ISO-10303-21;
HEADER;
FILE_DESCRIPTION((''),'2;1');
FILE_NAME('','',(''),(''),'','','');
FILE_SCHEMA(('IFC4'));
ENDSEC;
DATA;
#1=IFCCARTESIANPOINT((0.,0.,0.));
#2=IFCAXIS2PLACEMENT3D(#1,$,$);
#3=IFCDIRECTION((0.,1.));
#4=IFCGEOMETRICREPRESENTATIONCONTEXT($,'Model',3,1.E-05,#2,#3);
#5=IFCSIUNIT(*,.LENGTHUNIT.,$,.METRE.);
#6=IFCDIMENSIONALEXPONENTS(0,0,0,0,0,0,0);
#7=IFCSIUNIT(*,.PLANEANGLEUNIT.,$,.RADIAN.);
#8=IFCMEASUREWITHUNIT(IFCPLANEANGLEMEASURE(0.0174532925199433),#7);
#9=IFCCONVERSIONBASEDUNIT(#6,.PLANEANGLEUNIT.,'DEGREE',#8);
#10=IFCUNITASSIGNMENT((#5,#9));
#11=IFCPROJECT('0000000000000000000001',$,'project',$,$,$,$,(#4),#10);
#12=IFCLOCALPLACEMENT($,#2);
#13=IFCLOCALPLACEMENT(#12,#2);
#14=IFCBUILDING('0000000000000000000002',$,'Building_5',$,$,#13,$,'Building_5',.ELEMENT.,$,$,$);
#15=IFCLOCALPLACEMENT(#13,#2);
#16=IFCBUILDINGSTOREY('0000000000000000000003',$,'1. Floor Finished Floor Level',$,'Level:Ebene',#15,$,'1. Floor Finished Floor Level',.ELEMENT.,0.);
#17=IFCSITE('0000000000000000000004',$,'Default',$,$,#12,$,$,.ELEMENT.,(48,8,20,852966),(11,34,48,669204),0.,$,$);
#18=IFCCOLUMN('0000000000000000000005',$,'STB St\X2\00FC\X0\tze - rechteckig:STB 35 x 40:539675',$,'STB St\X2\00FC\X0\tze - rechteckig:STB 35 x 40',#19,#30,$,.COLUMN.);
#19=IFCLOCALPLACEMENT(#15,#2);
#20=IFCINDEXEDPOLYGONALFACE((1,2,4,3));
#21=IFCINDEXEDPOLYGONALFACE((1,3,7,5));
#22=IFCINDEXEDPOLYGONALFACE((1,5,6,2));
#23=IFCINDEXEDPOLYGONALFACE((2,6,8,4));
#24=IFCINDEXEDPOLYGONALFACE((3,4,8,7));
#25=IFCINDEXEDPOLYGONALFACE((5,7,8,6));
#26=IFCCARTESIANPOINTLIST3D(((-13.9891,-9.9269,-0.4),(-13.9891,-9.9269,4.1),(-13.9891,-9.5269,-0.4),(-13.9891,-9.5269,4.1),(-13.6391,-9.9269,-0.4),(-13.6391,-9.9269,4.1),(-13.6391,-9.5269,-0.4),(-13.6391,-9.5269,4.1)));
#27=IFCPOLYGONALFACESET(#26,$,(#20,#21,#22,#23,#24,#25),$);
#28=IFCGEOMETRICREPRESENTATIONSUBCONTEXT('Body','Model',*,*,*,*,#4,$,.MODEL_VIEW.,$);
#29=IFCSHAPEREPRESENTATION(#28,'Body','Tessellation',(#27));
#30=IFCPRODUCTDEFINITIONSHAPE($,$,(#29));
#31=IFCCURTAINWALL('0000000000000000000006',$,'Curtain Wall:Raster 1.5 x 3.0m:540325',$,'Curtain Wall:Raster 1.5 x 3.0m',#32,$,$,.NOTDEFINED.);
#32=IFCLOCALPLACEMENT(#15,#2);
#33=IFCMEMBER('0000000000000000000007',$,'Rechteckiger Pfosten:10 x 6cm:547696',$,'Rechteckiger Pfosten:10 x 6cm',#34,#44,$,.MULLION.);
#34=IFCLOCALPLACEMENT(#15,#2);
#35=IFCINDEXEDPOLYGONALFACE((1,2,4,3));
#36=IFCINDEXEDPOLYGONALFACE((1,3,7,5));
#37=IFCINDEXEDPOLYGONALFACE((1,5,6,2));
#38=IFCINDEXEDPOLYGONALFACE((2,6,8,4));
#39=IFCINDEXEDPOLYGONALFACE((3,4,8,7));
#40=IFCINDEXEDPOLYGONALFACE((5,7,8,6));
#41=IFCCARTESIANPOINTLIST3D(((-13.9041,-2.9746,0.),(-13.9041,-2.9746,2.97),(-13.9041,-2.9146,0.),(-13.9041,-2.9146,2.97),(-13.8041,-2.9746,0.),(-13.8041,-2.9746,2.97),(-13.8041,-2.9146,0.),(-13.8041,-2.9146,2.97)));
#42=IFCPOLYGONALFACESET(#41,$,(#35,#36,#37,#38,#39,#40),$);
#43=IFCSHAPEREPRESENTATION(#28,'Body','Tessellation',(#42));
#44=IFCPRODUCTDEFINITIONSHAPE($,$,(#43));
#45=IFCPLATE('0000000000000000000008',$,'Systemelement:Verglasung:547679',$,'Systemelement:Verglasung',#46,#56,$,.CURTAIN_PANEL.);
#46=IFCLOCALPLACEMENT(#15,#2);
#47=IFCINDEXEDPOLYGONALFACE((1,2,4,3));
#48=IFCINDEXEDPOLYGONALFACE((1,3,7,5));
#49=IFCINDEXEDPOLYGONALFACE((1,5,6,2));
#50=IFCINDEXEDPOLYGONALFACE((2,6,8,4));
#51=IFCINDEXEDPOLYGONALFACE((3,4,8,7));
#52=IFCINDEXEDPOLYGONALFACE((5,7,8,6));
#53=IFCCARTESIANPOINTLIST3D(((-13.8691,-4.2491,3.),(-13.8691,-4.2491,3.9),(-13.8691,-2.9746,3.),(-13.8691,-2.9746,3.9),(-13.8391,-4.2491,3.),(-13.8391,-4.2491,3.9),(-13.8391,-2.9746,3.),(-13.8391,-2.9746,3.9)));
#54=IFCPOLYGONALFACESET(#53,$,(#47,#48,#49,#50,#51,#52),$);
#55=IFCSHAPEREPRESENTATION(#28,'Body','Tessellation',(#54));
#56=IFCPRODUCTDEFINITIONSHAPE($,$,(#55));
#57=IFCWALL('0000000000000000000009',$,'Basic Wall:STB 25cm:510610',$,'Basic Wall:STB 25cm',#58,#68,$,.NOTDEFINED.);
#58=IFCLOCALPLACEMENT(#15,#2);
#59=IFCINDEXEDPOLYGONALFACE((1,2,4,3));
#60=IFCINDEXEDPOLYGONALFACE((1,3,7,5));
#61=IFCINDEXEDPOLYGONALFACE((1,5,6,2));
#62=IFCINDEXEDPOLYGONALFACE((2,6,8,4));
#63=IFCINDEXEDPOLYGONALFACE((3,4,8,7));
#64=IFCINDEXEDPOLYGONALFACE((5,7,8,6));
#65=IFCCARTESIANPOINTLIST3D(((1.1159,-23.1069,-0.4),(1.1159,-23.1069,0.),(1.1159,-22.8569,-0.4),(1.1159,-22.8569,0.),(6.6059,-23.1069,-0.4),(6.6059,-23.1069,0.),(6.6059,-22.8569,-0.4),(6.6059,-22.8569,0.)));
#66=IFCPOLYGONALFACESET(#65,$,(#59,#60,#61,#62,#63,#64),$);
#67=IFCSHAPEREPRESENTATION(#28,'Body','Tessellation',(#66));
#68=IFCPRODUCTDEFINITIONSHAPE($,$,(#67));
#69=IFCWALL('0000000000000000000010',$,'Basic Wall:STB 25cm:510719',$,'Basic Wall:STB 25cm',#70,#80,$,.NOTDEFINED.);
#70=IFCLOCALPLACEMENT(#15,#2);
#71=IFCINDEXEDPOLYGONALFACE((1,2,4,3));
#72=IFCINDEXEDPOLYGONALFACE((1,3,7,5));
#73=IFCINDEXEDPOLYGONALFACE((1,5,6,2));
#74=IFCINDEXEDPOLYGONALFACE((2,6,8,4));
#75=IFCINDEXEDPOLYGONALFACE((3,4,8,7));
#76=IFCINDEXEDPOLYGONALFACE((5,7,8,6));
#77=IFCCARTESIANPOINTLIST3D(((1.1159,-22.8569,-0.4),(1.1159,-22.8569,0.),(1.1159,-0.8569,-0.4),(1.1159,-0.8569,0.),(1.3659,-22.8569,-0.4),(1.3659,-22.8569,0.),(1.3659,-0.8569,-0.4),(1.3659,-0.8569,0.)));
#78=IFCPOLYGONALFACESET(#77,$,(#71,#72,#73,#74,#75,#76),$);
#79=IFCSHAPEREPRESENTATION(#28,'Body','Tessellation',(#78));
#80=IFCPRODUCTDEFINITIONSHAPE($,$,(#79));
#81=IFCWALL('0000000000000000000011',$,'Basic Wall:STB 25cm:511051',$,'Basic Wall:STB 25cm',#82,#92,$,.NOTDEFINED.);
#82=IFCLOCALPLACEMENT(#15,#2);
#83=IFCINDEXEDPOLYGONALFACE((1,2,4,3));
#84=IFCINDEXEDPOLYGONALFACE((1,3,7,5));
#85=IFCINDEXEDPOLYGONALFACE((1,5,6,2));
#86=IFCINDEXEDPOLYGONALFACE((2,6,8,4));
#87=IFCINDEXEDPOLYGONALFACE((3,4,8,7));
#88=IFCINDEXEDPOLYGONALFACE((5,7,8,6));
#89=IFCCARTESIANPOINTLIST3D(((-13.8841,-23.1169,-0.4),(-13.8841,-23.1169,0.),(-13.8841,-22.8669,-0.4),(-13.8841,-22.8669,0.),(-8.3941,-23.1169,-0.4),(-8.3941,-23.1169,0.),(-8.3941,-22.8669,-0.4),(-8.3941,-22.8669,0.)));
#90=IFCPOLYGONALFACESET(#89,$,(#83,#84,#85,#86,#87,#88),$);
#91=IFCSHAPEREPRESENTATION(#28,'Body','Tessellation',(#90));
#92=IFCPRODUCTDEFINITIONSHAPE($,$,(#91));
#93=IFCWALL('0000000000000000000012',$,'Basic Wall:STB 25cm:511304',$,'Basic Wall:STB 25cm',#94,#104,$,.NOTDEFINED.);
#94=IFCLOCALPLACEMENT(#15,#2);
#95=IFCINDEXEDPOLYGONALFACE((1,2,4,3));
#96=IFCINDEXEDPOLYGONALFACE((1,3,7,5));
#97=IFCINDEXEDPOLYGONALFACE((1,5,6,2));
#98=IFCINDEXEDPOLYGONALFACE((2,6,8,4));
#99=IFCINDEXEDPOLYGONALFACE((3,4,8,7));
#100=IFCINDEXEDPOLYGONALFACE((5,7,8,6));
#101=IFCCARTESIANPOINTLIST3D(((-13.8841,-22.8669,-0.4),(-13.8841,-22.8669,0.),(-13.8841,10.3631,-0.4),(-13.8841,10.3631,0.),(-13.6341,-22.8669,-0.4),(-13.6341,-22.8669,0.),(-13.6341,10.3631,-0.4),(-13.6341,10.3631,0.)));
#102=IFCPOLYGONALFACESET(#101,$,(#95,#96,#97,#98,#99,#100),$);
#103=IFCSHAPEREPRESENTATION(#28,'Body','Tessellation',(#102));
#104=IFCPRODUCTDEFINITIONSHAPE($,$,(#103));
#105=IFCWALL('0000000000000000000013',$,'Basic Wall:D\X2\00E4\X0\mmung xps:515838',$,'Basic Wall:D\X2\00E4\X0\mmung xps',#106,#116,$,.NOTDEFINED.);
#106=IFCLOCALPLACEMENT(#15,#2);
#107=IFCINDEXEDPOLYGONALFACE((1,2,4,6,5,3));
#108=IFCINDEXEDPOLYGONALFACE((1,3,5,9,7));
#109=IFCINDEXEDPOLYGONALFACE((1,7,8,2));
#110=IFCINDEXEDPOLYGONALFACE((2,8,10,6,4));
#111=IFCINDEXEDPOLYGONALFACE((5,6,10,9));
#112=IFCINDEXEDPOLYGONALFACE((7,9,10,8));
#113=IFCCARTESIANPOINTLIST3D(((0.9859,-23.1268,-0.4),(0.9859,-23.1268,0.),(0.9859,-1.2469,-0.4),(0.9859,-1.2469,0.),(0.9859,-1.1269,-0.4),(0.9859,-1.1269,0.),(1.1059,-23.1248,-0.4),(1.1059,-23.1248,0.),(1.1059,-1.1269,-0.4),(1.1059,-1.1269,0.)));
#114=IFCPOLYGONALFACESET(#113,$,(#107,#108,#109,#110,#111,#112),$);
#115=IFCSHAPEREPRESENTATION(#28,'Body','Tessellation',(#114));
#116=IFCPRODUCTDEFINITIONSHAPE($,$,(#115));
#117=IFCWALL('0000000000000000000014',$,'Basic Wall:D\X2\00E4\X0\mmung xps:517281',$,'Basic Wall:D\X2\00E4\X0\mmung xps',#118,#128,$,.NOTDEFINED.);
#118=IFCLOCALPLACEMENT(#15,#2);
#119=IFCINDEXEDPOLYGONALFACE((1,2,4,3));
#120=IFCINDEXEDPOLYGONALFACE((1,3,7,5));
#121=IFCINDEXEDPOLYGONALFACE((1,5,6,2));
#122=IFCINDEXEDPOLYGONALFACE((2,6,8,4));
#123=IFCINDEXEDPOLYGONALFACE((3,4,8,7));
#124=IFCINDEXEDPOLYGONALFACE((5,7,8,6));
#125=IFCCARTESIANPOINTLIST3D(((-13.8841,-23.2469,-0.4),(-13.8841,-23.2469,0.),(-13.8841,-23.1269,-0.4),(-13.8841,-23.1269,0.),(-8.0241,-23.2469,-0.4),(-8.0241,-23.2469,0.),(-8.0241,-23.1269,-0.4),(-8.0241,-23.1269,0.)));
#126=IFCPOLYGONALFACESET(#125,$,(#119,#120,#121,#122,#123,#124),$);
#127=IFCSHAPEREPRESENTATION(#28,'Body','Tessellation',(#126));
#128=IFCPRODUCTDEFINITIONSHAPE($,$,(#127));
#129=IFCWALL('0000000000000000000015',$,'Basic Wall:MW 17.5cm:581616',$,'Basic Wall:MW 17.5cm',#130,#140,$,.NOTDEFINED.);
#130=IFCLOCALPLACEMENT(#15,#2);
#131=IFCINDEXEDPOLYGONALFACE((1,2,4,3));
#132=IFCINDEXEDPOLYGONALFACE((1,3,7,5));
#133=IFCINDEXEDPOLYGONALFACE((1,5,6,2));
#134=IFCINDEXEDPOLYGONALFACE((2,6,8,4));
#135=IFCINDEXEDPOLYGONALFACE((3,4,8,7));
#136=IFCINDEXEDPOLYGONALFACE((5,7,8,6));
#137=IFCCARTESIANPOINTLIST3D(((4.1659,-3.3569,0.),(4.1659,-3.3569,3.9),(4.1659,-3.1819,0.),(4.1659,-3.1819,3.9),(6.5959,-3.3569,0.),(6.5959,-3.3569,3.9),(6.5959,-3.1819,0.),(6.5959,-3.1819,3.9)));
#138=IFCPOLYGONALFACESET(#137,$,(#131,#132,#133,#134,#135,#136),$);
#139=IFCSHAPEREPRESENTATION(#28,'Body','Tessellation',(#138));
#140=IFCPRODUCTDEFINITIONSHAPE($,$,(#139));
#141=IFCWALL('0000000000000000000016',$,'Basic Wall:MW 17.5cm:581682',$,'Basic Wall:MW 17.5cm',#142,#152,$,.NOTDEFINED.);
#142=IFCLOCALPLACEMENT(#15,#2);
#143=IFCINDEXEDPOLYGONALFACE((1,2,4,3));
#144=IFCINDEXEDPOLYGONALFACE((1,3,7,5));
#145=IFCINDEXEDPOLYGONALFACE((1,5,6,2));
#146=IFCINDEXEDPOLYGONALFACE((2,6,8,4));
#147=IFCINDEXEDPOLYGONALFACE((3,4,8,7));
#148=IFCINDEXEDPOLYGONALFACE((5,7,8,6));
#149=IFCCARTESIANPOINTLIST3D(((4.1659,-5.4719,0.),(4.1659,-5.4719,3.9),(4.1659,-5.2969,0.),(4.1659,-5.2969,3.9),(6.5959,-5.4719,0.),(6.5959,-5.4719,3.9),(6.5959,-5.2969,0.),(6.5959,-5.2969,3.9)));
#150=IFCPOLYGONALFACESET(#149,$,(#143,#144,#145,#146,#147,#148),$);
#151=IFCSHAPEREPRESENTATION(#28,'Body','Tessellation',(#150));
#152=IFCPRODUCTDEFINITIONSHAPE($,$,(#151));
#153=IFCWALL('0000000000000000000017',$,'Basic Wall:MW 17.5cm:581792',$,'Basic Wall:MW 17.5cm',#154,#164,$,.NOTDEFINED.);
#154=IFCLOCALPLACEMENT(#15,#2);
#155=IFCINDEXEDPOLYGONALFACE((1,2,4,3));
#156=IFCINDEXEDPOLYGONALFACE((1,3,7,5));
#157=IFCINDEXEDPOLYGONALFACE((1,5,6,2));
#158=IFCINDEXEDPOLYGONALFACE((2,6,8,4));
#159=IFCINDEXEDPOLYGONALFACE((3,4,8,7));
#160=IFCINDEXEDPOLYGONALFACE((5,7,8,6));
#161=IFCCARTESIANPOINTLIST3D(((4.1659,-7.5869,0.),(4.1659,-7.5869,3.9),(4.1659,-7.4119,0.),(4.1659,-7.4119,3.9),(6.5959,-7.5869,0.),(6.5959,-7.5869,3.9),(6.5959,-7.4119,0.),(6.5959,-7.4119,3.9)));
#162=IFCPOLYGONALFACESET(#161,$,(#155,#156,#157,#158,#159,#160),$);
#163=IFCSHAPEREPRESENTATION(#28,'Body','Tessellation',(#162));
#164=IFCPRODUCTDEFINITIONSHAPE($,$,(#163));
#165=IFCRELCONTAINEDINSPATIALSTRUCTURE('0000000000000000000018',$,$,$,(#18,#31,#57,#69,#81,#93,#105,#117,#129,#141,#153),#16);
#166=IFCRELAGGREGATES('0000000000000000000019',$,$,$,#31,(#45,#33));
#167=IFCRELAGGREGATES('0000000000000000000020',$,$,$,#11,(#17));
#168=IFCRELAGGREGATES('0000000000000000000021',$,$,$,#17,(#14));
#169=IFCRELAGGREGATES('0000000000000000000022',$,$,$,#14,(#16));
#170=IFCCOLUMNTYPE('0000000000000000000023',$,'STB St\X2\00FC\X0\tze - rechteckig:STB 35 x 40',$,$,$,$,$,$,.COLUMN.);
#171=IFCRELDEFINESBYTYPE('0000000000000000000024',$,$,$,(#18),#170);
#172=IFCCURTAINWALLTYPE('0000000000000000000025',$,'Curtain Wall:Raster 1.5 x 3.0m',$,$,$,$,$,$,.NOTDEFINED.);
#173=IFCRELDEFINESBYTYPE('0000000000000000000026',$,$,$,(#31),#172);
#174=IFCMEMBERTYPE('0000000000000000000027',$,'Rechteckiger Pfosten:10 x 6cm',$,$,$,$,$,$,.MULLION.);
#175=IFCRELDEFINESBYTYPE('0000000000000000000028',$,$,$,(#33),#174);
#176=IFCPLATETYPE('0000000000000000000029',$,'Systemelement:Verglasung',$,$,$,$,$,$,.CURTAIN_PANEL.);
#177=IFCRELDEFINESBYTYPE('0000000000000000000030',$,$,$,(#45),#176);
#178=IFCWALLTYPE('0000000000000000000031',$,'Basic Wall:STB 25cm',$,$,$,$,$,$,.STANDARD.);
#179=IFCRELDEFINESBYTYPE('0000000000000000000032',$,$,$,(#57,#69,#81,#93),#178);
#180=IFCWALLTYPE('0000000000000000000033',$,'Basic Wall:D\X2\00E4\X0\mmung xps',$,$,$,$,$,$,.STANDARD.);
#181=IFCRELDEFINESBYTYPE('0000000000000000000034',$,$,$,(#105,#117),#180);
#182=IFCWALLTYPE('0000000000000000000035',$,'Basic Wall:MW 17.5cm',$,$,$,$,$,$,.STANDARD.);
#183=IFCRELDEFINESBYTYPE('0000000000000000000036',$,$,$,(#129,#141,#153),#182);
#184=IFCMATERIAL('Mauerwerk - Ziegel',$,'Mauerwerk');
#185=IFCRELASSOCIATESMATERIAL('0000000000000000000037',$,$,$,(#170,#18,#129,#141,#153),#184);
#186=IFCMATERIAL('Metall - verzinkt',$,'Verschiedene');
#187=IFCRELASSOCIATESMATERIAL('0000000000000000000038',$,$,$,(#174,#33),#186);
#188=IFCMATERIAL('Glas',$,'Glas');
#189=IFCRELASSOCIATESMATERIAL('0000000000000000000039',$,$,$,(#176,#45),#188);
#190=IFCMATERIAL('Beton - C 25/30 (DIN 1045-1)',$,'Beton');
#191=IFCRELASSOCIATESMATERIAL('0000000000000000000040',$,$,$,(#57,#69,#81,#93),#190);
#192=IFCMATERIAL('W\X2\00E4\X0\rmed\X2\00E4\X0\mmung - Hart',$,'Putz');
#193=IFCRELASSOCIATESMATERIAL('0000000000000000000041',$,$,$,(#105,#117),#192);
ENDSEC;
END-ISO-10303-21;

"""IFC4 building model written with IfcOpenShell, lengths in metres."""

from ifc_helpers import new_model, entity, si_unit, converted_unit, direction, frame, origin, place, context, subcontext, project, spatial, indexed_curve, outline, extrude, source, transform, mapped, material, type_object, type_shapes, element, aggregate, save


model = new_model("IFC4")

# Units and contexts
model_context = context("Model", 3, precision=1e-05, world=origin(), true_north=direction((0.0, 1.0)))
body_context = subcontext(model_context, "Body", "Model", "MODEL_VIEW")
ifc_project = project(units=[si_unit("LENGTHUNIT", "METRE"), converted_unit("PLANEANGLEUNIT", "DEGREE", entity("IfcPlaneAngleMeasure", 0.0174532925199433), si_unit("PLANEANGLEUNIT", "RADIAN"), dimensions=[0, 0, 0, 0, 0, 0, 0])], contexts=[model_context])

# Site, building, storey
site_placement = place(None, origin())
site = spatial("IfcSite", under=ifc_project, at=site_placement, Name="Default", CompositionType="ELEMENT", RefLatitude=(48, 8, 20, 852966), RefLongitude=(11, 34, 48, 669204), RefElevation=0.0)
building_placement = place(site_placement, origin())
building = spatial("IfcBuilding", under=site, at=building_placement, Name="Building_5", LongName="Building_5", CompositionType="ELEMENT")
storey_placement = place(building_placement, origin())
storey = spatial("IfcBuildingStorey", under=building, at=storey_placement, Name="1. Floor Finished Floor Level", ObjectType="Level:Ebene", LongName="1. Floor Finished Floor Level", CompositionType="ELEMENT", Elevation=0.0)

# Column
ifc_material_1 = material(Name="Mauerwerk - Ziegel", Category="Mauerwerk")
column_type = type_object("IfcColumnType", Name="STB Stütze - rechteckig:STB 35 x 40", PredefinedType="COLUMN", material=ifc_material_1)
shared_shape_1 = source(origin(), body_context, "Body", "SweptSolid", [
    extrude(outline(indexed_curve([(-0.175, -0.2), (0.175, -0.2), (0.175, 0.2), (-0.175, 0.2), (-0.175, -0.2)], self_intersect=False)), frame((0.0, 0.0, -0.4), z_axis=(0.0, 0.0, 1.0), x_axis=(-1.0, 0.0, 0.0)), (0.0, 0.0, 1.0), 4.5),
])
type_shapes(column_type, [shared_shape_1])
column_placement = place(storey_placement, frame((-13.8141, -9.7269, 0.0)))
element("IfcColumn", 1, at=column_placement, inside=storey, type_object=column_type, material=ifc_material_1, Name="STB Stütze - rechteckig:STB 35 x 40:539675", ObjectType="STB Stütze - rechteckig:STB 35 x 40", PredefinedType="COLUMN", context=body_context, shape_type="MappedRepresentation", body=[
    mapped(shared_shape_1, transform((0.0, 0.0, 0.0), scale=1.0)),
])

# Curtain wall, member
curtain_wall_type = type_object("IfcCurtainWallType", Name="Curtain Wall:Raster 1.5 x 3.0m", PredefinedType="NOTDEFINED")
curtain_wall_placement = place(storey_placement, origin())
curtain_wall = element("IfcCurtainWall", 2, at=curtain_wall_placement, inside=storey, type_object=curtain_wall_type, Name="Curtain Wall:Raster 1.5 x 3.0m:540325", ObjectType="Curtain Wall:Raster 1.5 x 3.0m", PredefinedType="NOTDEFINED")
ifc_material_2 = material(Name="Metall - verzinkt", Category="Verschiedene")
member_type = type_object("IfcMemberType", Name="Rechteckiger Pfosten:10 x 6cm", PredefinedType="MULLION", material=ifc_material_2)
shared_shape_2 = source(origin(), body_context, "Body", "SweptSolid", [
    extrude(outline(indexed_curve([(-0.03, -0.05), (0.03, -0.05), (0.03, 0.05), (-0.03, 0.05), (-0.03, -0.05)], self_intersect=False)), frame((0.0, 0.0, -2.97), z_axis=(0.0, 0.0, 1.0), x_axis=(-1.0, 0.0, 0.0)), (0.0, 0.0, 1.0), 2.97),
])
type_shapes(member_type, [shared_shape_2])
member_placement = place(curtain_wall_placement, frame((-13.8541, -2.9446, 0.0), z_axis=(0.0, 0.0, -1.0), x_axis=(0.0, -1.0, 0.0)))
member = element("IfcMember", 3, at=member_placement, type_object=member_type, material=ifc_material_2, Name="Rechteckiger Pfosten:10 x 6cm:547696", ObjectType="Rechteckiger Pfosten:10 x 6cm", PredefinedType="MULLION", context=body_context, shape_type="MappedRepresentation", body=[
    mapped(shared_shape_2, transform((0.0, 0.0, 0.0), scale=1.0)),
])

# Shared definitions
ifc_material_3 = material(Name="Beton - C 25/30 (DIN 1045-1)", Category="Beton")

# Plate
ifc_material_4 = material(Name="Glas", Category="Glas")
plate_type = type_object("IfcPlateType", Name="Systemelement:Verglasung", PredefinedType="CURTAIN_PANEL", material=ifc_material_4)
shared_shape_3 = source(origin(), body_context, "Body", "SweptSolid", [
    extrude(outline(indexed_curve([(-0.015, -0.6372), (0.015, -0.6372), (0.015, 0.6372), (-0.015, 0.6372), (-0.015, -0.6372)], self_intersect=False)), frame((0.0, 0.0, 0.0), z_axis=(0.0, 0.0, 1.0), x_axis=(0.0, 1.0, 0.0)), (0.0, 0.0, 1.0), 0.9),
])
type_shapes(plate_type, [shared_shape_3])
plate_placement = place(curtain_wall_placement, frame((-13.8541, -3.6119, 3.0), z_axis=(0.0, 0.0, 1.0), x_axis=(0.0, -1.0, 0.0)))
plate = element("IfcPlate", 4, at=plate_placement, type_object=plate_type, material=ifc_material_4, Name="Systemelement:Verglasung:547679", ObjectType="Systemelement:Verglasung", PredefinedType="CURTAIN_PANEL", context=body_context, shape_type="MappedRepresentation", body=[
    mapped(shared_shape_3, transform((0.0, 0.0, 0.0), scale=1.0)),
])
aggregate(curtain_wall, [plate, member])

# Shared definitions
ifc_material_5 = material(Name="Wärmedämmung - Hart", Category="Putz")

# Walls
wall_type_1 = type_object("IfcWallType", Name="Basic Wall:STB 25cm", PredefinedType="STANDARD")
wall_1_placement = place(storey_placement, frame((6.6059, -22.9819, -0.4), z_axis=(0.0, 0.0, 1.0), x_axis=(-1.0, 0.0, 0.0)))
element("IfcWall", 5, at=wall_1_placement, inside=storey, type_object=wall_type_1, material=ifc_material_3, Name="Basic Wall:STB 25cm:510610", ObjectType="Basic Wall:STB 25cm", PredefinedType="NOTDEFINED", context=body_context, shape_type="SweptSolid", body=[
    extrude(outline(indexed_curve([(5.49, 0.125), (0.0, 0.125), (0.0, -0.125), (5.49, -0.125), (5.49, 0.125)], self_intersect=False)), origin(), (0.0, 0.0, 1.0), 0.4),
])
wall_2_placement = place(storey_placement, frame((1.2409, -22.8569, -0.4), z_axis=(0.0, 0.0, 1.0), x_axis=(0.0, 1.0, 0.0)))
element("IfcWall", 6, at=wall_2_placement, inside=storey, type_object=wall_type_1, material=ifc_material_3, Name="Basic Wall:STB 25cm:510719", ObjectType="Basic Wall:STB 25cm", PredefinedType="NOTDEFINED", context=body_context, shape_type="SweptSolid", body=[
    extrude(outline(indexed_curve([(22.0, 0.125), (0.0, 0.125), (0.0, -0.125), (22.0, -0.125), (22.0, 0.125)], self_intersect=False)), origin(), (0.0, 0.0, 1.0), 0.4),
])
wall_3_placement = place(storey_placement, frame((-8.3941, -22.9919, -0.4), z_axis=(0.0, 0.0, 1.0), x_axis=(-1.0, 0.0, 0.0)))
element("IfcWall", 7, at=wall_3_placement, inside=storey, type_object=wall_type_1, material=ifc_material_3, Name="Basic Wall:STB 25cm:511051", ObjectType="Basic Wall:STB 25cm", PredefinedType="NOTDEFINED", context=body_context, shape_type="SweptSolid", body=[
    extrude(outline(indexed_curve([(5.49, 0.125), (0.0, 0.125), (0.0, -0.125), (5.49, -0.125), (5.49, 0.125)], self_intersect=False)), origin(), (0.0, 0.0, 1.0), 0.4),
])
wall_4_placement = place(storey_placement, frame((-13.7591, -22.8669, -0.4), z_axis=(0.0, 0.0, 1.0), x_axis=(0.0, 1.0, 0.0)))
element("IfcWall", 8, at=wall_4_placement, inside=storey, type_object=wall_type_1, material=ifc_material_3, Name="Basic Wall:STB 25cm:511304", ObjectType="Basic Wall:STB 25cm", PredefinedType="NOTDEFINED", context=body_context, shape_type="SweptSolid", body=[
    extrude(outline(indexed_curve([(33.23, 0.125), (0.0, 0.125), (0.0, -0.125), (33.23, -0.125), (33.23, 0.125)], self_intersect=False)), origin(), (0.0, 0.0, 1.0), 0.4),
])
wall_type_2 = type_object("IfcWallType", Name="Basic Wall:Dämmung xps", PredefinedType="STANDARD")
wall_5_placement = place(storey_placement, frame((1.0459, -23.1268, -0.4), z_axis=(0.0, 0.0, 1.0), x_axis=(0.0, 1.0, 0.0)))
element("IfcWall", 9, at=wall_5_placement, inside=storey, type_object=wall_type_2, material=ifc_material_5, Name="Basic Wall:Dämmung xps:515838", ObjectType="Basic Wall:Dämmung xps", PredefinedType="NOTDEFINED", context=body_context, shape_type="SweptSolid", body=[
    extrude(outline(indexed_curve([(22.0, -0.06), (22.0, 0.06), (21.88, 0.06), (0.0, 0.06), (0.002, -0.06), (22.0, -0.06)], self_intersect=False)), origin(), (0.0, 0.0, 1.0), 0.4),
])
wall_6_placement = place(storey_placement, frame((-8.0241, -23.1869, -0.4), z_axis=(0.0, 0.0, 1.0), x_axis=(-1.0, 0.0, 0.0)))
element("IfcWall", 10, at=wall_6_placement, inside=storey, type_object=wall_type_2, material=ifc_material_5, Name="Basic Wall:Dämmung xps:517281", ObjectType="Basic Wall:Dämmung xps", PredefinedType="NOTDEFINED", context=body_context, shape_type="SweptSolid", body=[
    extrude(outline(indexed_curve([(5.86, 0.06), (0.0, 0.06), (0.0, -0.06), (5.86, -0.06), (5.86, 0.06)], self_intersect=False)), origin(), (0.0, 0.0, 1.0), 0.4),
])

# Walls
wall_type_3 = type_object("IfcWallType", Name="Basic Wall:MW 17.5cm", PredefinedType="STANDARD")
wall_7_placement = place(storey_placement, frame((4.1659, -3.2694, 0.0)))
element("IfcWall", 11, at=wall_7_placement, inside=storey, type_object=wall_type_3, material=ifc_material_1, Name="Basic Wall:MW 17.5cm:581616", ObjectType="Basic Wall:MW 17.5cm", PredefinedType="NOTDEFINED", context=body_context, shape_type="SweptSolid", body=[
    extrude(outline(indexed_curve([(2.43, 0.0875), (0.0, 0.0875), (0.0, -0.0875), (2.43, -0.0875), (2.43, 0.0875)], self_intersect=False)), origin(), (0.0, 0.0, 1.0), 3.9),
])
wall_8_placement = place(storey_placement, frame((4.1659, -5.3844, 0.0)))
element("IfcWall", 12, at=wall_8_placement, inside=storey, type_object=wall_type_3, material=ifc_material_1, Name="Basic Wall:MW 17.5cm:581682", ObjectType="Basic Wall:MW 17.5cm", PredefinedType="NOTDEFINED", context=body_context, shape_type="SweptSolid", body=[
    extrude(outline(indexed_curve([(2.43, 0.0875), (0.0, 0.0875), (0.0, -0.0875), (2.43, -0.0875), (2.43, 0.0875)], self_intersect=False)), origin(), (0.0, 0.0, 1.0), 3.9),
])
wall_9_placement = place(storey_placement, frame((4.1659, -7.4994, 0.0)))
element("IfcWall", 13, at=wall_9_placement, inside=storey, type_object=wall_type_3, material=ifc_material_1, Name="Basic Wall:MW 17.5cm:581792", ObjectType="Basic Wall:MW 17.5cm", PredefinedType="NOTDEFINED", context=body_context, shape_type="SweptSolid", body=[
    extrude(outline(indexed_curve([(2.43, 0.0875), (0.0, 0.0875), (0.0, -0.0875), (2.43, -0.0875), (2.43, 0.0875)], self_intersect=False)), origin(), (0.0, 0.0, 1.0), 3.9),
])

save(model, "model.ifc")
